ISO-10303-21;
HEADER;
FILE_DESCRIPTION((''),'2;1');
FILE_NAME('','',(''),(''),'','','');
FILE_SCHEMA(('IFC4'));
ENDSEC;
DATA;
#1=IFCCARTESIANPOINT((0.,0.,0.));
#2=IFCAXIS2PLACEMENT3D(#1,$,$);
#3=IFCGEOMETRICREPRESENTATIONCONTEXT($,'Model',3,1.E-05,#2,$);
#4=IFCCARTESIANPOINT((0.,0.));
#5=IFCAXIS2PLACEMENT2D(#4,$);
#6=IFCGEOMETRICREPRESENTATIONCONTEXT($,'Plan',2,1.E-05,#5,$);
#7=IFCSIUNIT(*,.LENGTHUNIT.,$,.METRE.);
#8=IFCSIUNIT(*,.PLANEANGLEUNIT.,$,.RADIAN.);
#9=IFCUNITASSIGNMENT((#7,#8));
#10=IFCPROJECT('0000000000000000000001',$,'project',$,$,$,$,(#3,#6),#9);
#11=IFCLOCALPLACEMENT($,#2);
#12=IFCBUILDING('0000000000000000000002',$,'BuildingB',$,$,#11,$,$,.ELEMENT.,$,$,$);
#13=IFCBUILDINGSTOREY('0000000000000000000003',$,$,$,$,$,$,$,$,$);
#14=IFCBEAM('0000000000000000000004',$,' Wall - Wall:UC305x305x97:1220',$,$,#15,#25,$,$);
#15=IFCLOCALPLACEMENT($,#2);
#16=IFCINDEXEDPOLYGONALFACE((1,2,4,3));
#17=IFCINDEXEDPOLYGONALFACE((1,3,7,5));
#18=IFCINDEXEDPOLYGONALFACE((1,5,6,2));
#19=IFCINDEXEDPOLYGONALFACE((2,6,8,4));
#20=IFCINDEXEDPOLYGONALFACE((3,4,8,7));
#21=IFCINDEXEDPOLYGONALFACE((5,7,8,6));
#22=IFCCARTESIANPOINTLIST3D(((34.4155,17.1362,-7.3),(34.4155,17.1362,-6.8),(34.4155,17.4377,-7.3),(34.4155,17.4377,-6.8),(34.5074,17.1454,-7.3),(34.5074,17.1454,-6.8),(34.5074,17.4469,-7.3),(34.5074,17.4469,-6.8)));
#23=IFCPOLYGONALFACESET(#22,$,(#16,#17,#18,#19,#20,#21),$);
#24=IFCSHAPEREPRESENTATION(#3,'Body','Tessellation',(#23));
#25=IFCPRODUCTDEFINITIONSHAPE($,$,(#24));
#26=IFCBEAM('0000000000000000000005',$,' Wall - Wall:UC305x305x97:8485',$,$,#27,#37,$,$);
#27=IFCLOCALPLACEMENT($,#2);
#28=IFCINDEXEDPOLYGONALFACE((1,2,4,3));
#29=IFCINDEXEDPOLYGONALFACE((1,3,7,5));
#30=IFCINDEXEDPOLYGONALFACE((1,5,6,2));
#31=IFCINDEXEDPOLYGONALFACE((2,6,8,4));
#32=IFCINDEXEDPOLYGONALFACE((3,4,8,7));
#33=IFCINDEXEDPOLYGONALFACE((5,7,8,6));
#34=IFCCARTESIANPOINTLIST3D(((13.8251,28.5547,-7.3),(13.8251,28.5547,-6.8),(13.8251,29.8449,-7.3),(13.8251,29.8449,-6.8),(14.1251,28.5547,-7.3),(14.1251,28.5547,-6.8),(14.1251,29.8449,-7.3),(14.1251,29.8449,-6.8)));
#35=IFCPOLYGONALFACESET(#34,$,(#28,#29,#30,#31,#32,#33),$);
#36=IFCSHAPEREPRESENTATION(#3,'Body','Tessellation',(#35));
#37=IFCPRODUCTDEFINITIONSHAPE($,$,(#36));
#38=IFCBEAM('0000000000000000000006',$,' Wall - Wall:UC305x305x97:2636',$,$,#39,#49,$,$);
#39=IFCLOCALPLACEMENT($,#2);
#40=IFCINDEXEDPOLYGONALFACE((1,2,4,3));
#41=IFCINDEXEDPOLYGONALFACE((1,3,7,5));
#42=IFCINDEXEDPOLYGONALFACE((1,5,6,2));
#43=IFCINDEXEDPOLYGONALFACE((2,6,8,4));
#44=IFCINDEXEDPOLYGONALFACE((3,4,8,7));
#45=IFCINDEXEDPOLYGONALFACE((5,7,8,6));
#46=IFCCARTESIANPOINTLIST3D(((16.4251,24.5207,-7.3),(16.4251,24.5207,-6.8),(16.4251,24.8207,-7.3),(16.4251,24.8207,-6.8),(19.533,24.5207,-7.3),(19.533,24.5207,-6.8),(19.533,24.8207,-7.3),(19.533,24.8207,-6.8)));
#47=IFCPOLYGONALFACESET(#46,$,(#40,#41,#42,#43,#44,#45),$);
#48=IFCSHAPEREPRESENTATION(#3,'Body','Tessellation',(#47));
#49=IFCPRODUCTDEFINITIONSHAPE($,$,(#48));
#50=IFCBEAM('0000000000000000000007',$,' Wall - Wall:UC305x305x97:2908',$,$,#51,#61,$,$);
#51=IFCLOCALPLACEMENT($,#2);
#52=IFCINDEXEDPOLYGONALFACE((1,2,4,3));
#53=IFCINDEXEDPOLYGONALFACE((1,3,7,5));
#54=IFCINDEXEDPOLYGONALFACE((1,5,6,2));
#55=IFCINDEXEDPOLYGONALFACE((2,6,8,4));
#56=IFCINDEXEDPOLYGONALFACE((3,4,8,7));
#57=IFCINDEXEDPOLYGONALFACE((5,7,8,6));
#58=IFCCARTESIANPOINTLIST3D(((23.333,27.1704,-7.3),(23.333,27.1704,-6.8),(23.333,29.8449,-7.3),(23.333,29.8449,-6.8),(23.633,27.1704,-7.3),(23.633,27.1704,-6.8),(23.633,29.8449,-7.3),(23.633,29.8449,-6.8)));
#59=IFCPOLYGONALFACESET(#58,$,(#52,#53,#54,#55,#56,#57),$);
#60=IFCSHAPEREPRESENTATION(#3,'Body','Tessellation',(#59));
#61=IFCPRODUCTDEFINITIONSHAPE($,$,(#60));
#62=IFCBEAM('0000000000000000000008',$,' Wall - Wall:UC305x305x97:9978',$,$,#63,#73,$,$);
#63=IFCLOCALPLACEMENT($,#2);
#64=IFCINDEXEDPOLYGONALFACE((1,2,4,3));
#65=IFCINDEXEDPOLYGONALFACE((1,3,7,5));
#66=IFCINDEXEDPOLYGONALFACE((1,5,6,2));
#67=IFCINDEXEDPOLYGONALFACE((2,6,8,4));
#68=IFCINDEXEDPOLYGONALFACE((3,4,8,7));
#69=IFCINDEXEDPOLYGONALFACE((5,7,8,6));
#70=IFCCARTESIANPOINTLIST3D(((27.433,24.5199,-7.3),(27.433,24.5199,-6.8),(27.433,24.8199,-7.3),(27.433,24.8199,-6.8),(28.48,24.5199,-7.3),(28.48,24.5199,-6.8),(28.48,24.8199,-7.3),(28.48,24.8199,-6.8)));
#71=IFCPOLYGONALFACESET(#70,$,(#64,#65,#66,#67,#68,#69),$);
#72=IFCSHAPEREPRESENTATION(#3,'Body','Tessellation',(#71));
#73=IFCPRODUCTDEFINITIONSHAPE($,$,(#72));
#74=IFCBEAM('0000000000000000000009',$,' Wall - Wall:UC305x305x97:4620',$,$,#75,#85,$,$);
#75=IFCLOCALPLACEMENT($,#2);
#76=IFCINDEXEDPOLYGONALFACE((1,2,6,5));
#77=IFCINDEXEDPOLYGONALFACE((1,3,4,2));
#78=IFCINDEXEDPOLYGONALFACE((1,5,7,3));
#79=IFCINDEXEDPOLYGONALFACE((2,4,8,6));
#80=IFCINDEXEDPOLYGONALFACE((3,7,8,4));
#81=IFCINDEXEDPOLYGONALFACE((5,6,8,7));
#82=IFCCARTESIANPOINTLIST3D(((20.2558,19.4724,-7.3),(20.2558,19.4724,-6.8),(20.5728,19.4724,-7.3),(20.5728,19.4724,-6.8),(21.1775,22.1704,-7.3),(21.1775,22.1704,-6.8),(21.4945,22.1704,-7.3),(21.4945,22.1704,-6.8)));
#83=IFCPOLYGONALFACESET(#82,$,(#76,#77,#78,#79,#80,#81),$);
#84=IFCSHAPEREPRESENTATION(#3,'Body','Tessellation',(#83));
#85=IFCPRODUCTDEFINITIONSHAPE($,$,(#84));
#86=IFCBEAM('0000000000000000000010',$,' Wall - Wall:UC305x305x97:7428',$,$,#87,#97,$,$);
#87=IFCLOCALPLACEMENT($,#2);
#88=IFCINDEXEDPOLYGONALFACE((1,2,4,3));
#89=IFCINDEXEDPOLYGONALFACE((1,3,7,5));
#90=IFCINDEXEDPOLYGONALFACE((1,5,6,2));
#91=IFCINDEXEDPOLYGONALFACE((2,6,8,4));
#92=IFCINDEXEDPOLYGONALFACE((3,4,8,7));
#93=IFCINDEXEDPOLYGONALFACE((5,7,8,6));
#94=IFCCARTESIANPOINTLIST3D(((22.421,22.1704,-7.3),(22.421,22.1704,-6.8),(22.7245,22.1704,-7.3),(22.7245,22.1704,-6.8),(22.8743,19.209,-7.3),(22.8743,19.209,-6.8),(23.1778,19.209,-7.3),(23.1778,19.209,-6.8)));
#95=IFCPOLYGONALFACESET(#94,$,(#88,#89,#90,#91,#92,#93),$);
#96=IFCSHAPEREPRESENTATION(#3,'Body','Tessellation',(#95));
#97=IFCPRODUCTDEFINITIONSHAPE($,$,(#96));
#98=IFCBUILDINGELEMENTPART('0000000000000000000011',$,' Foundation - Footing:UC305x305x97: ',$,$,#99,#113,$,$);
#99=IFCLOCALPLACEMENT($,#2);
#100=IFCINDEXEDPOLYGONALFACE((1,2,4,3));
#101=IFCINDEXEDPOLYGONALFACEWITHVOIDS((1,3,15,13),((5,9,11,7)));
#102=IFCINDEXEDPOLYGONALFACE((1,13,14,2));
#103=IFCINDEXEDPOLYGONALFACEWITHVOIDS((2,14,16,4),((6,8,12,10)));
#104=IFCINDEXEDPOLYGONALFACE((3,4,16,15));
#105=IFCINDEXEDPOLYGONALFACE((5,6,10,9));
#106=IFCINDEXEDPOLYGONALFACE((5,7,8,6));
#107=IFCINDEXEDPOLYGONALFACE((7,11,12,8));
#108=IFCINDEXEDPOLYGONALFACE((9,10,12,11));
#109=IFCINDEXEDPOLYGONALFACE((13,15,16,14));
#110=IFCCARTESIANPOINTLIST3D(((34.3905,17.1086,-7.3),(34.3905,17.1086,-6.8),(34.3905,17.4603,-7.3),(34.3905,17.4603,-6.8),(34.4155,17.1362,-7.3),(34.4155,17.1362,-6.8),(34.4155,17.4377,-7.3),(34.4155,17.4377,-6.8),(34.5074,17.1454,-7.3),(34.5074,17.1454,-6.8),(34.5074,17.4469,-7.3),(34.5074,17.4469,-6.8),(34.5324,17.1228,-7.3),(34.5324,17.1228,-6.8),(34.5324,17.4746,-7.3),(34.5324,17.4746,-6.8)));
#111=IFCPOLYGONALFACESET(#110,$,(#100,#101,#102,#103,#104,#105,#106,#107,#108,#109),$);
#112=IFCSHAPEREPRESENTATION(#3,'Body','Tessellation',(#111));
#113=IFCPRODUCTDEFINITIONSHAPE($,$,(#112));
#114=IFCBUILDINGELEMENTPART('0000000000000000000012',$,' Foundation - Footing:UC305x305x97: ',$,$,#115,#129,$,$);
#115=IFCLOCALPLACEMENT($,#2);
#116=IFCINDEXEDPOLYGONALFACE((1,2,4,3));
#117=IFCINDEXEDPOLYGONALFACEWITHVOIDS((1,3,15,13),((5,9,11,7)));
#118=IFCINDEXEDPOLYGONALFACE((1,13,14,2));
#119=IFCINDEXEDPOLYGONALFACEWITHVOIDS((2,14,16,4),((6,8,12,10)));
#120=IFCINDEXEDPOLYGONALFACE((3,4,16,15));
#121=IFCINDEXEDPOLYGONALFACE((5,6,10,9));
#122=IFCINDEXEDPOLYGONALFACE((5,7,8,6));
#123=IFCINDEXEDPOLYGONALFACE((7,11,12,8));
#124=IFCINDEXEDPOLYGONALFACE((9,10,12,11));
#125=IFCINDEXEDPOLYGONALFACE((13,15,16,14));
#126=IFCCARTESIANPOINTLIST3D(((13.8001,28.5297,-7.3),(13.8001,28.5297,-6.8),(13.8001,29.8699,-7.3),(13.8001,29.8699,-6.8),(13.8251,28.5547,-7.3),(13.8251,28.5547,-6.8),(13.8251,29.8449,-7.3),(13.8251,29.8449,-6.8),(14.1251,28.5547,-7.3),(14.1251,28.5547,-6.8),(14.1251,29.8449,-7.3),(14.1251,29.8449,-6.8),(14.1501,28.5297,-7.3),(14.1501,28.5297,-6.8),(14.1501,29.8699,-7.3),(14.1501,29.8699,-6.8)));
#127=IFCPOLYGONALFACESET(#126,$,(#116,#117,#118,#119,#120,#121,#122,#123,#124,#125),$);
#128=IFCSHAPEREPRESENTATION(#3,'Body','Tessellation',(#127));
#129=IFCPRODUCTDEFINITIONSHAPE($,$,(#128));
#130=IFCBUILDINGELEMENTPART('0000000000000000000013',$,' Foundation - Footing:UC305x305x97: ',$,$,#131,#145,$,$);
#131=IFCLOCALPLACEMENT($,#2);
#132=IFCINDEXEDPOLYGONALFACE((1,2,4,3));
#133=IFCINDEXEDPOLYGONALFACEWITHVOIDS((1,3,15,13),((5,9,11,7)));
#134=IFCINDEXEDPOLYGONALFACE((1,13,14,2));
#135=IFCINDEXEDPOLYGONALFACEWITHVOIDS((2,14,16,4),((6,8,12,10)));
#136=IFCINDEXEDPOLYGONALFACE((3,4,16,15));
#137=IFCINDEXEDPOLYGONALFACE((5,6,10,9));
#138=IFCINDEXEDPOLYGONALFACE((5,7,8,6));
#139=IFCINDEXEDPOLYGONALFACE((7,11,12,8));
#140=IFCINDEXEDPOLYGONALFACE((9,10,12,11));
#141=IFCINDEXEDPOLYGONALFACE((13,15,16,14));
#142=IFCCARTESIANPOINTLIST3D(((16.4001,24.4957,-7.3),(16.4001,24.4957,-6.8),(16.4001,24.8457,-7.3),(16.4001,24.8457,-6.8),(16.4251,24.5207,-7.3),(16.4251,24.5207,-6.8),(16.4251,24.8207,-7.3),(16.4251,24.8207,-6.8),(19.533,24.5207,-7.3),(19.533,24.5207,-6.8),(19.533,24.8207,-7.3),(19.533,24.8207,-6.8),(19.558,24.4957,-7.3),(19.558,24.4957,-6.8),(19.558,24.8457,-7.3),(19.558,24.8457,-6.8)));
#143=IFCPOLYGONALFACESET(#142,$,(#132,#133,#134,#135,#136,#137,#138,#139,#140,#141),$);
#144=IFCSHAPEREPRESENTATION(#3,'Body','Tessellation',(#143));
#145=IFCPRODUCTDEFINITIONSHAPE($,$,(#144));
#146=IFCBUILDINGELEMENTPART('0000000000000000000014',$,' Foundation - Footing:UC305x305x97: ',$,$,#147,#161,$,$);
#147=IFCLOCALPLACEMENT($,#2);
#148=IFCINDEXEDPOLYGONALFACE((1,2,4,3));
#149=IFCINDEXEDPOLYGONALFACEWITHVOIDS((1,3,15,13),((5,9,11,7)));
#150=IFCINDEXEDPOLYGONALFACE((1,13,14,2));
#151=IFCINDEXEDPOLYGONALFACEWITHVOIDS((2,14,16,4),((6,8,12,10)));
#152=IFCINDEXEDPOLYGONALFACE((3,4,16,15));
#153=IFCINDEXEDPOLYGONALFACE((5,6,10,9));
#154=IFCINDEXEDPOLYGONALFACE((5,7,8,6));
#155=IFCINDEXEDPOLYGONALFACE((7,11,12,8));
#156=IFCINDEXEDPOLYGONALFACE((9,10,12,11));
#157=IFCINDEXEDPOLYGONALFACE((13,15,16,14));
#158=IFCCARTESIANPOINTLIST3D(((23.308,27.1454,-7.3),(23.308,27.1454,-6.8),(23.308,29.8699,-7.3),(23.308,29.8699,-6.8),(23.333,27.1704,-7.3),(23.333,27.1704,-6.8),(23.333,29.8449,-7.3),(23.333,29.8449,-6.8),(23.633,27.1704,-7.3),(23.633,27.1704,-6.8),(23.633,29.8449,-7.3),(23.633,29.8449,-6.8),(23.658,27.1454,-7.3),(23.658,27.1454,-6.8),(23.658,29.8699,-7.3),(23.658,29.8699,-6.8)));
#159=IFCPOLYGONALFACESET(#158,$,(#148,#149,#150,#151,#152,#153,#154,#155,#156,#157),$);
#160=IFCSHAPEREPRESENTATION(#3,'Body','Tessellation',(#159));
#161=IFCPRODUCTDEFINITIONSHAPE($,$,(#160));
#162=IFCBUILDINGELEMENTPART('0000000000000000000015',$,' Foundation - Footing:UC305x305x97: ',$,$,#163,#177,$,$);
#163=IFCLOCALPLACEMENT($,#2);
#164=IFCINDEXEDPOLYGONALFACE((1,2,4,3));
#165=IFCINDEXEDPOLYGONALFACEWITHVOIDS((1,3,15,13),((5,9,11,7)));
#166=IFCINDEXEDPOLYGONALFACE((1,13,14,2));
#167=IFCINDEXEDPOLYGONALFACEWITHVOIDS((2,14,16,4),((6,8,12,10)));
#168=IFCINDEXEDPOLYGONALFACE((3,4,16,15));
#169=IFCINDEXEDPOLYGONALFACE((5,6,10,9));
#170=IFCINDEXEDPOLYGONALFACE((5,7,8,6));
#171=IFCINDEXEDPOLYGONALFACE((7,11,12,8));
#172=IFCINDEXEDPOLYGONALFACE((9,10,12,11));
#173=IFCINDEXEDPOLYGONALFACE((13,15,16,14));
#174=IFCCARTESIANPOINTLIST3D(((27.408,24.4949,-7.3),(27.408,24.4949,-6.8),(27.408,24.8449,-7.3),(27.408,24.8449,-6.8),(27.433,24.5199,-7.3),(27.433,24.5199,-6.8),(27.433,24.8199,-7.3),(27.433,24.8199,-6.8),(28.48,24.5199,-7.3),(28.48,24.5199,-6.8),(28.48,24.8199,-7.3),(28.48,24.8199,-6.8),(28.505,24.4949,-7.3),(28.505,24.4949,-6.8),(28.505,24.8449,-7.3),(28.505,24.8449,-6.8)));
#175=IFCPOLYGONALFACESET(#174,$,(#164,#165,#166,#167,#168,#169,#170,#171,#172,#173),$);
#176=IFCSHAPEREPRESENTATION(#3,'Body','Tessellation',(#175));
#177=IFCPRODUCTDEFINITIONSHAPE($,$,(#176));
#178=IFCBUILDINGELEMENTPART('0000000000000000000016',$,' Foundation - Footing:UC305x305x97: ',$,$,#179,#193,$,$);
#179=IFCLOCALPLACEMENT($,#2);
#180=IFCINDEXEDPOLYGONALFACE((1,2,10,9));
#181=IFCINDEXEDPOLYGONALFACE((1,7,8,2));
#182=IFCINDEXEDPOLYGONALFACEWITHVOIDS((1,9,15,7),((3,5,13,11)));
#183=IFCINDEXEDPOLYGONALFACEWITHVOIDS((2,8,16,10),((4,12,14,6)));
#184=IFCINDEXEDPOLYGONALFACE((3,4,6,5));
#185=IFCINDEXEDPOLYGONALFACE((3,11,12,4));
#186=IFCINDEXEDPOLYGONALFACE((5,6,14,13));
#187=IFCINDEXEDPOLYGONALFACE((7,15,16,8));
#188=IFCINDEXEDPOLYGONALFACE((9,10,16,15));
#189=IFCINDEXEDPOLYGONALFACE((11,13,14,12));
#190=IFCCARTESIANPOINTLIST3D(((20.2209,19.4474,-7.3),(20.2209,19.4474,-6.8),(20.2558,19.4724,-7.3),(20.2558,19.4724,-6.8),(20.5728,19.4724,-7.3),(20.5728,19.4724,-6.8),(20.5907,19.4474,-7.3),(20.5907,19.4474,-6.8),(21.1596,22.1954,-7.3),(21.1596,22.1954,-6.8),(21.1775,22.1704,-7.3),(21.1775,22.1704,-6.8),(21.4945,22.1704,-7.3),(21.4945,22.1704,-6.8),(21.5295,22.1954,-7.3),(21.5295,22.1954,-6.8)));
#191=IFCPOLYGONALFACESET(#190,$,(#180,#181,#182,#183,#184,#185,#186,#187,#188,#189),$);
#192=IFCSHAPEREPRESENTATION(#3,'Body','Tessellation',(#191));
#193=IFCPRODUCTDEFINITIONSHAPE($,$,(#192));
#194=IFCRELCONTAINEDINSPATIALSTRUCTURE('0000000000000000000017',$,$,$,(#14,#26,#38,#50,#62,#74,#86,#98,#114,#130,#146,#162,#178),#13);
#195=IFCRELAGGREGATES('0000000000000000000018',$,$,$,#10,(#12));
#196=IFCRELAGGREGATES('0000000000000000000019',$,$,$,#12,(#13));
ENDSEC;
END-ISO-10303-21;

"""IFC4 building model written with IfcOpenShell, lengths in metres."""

from ifc_helpers import new_model, si_unit, origin, origin_2d, place, context, project, spatial, polyline, outline, extrude, element, save


model = new_model("IFC4")

# Units and contexts
model_context = context("Model", 3, precision=1e-05, world=origin())
plan_context = context("Plan", 2, precision=1e-05, world=origin_2d())
ifc_project = project(units=[si_unit("LENGTHUNIT", "METRE"), si_unit("PLANEANGLEUNIT", "RADIAN")], contexts=[model_context, plan_context])

# Building, storey
building_placement = place(None, origin())
building = spatial("IfcBuilding", under=ifc_project, at=building_placement, Name="BuildingB", CompositionType="ELEMENT")
storey = spatial("IfcBuildingStorey", under=building)

# Beams
element("IfcBeam", 1, inside=storey, Name=" Wall - Wall:UC305x305x97:1220", context=model_context, shape_type="SweptSolid", body=[
    extrude(outline(polyline([(34.4155, 17.1362, -7.3), (34.5074, 17.1454, -7.3), (34.5074, 17.4469, -7.3), (34.4155, 17.4377, -7.3), (34.4155, 17.1362, -7.3)])), None, (0.0, 0.0, 1.0), 0.5),
])
element("IfcBeam", 2, inside=storey, Name=" Wall - Wall:UC305x305x97:8485", context=model_context, shape_type="SweptSolid", body=[
    extrude(outline(polyline([(13.8251, 28.5547, -7.3), (14.1251, 28.5547, -7.3), (14.1251, 29.8449, -7.3), (13.8251, 29.8449, -7.3), (13.8251, 28.5547, -7.3)])), None, (0.0, 0.0, 1.0), 0.5),
])
element("IfcBeam", 3, inside=storey, Name=" Wall - Wall:UC305x305x97:2636", context=model_context, shape_type="SweptSolid", body=[
    extrude(outline(polyline([(16.4251, 24.5207, -7.3), (16.4251, 24.8207, -7.3), (19.533, 24.8207, -7.3), (19.533, 24.5207, -7.3), (16.4251, 24.5207, -7.3)])), None, (0.0, 0.0, 1.0), 0.5),
])
element("IfcBeam", 4, inside=storey, Name=" Wall - Wall:UC305x305x97:2908", context=model_context, shape_type="SweptSolid", body=[
    extrude(outline(polyline([(23.333, 27.1704, -7.3), (23.633, 27.1704, -7.3), (23.633, 29.8449, -7.3), (23.333, 29.8449, -7.3), (23.333, 27.1704, -7.3)])), None, (0.0, 0.0, 1.0), 0.5),
])
element("IfcBeam", 5, inside=storey, Name=" Wall - Wall:UC305x305x97:9978", context=model_context, shape_type="SweptSolid", body=[
    extrude(outline(polyline([(27.433, 24.5199, -7.3), (27.433, 24.8199, -7.3), (28.48, 24.8199, -7.3), (28.48, 24.5199, -7.3), (27.433, 24.5199, -7.3)])), None, (0.0, 0.0, 1.0), 0.5),
])
element("IfcBeam", 6, inside=storey, Name=" Wall - Wall:UC305x305x97:4620", context=model_context, shape_type="SweptSolid", body=[
    extrude(outline(polyline([(20.2558, 19.4724, -7.3), (20.5728, 19.4724, -7.3), (21.4945, 22.1704, -7.3), (21.1775, 22.1704, -7.3), (20.2558, 19.4724, -7.3)])), None, (0.0, 0.0, 1.0), 0.5),
])
element("IfcBeam", 7, inside=storey, Name=" Wall - Wall:UC305x305x97:7428", context=model_context, shape_type="SweptSolid", body=[
    extrude(outline(polyline([(22.8743, 19.209, -7.3), (23.1778, 19.209, -7.3), (22.7245, 22.1704, -7.3), (22.421, 22.1704, -7.3), (22.8743, 19.209, -7.3)])), None, (0.0, 0.0, 1.0), 0.5),
])

# Building element parts, openings
building_element_part_1 = element("IfcBuildingElementPart", 8, inside=storey, Name=" Foundation - Footing:UC305x305x97: ", context=model_context, shape_type="SweptSolid", body=[
    extrude(outline(polyline([(34.3905, 17.1086, -7.3), (34.5324, 17.1228, -7.3), (34.5324, 17.4746, -7.3), (34.3905, 17.4603, -7.3), (34.3905, 17.1086, -7.3)])), None, (0.0, 0.0, 1.0), 0.5),
])
element("IfcOpeningElement", 9, inside=storey, cuts=building_element_part_1, context=model_context, shape_type="SweptSolid", body=[
    extrude(outline(polyline([(34.4155, 17.1362, -7.3), (34.5074, 17.1454, -7.3), (34.5074, 17.4469, -7.3), (34.4155, 17.4377, -7.3), (34.4155, 17.1362, -7.3)])), None, (0.0, 0.0, 1.0), 0.5),
])
building_element_part_2 = element("IfcBuildingElementPart", 10, inside=storey, Name=" Foundation - Footing:UC305x305x97: ", context=model_context, shape_type="SweptSolid", body=[
    extrude(outline(polyline([(13.8001, 28.5297, -7.3), (14.1501, 28.5297, -7.3), (14.1501, 29.8699, -7.3), (13.8001, 29.8699, -7.3), (13.8001, 28.5297, -7.3)])), None, (0.0, 0.0, 1.0), 0.5),
])
element("IfcOpeningElement", 11, inside=storey, cuts=building_element_part_2, context=model_context, shape_type="SweptSolid", body=[
    extrude(outline(polyline([(13.8251, 28.5547, -7.3), (14.1251, 28.5547, -7.3), (14.1251, 29.8449, -7.3), (13.8251, 29.8449, -7.3), (13.8251, 28.5547, -7.3)])), None, (0.0, 0.0, 1.0), 0.5),
])
building_element_part_3 = element("IfcBuildingElementPart", 12, inside=storey, Name=" Foundation - Footing:UC305x305x97: ", context=model_context, shape_type="SweptSolid", body=[
    extrude(outline(polyline([(16.4001, 24.4957, -7.3), (16.4001, 24.8457, -7.3), (19.558, 24.8457, -7.3), (19.558, 24.4957, -7.3), (16.4001, 24.4957, -7.3)])), None, (0.0, 0.0, 1.0), 0.5),
])
element("IfcOpeningElement", 13, inside=storey, cuts=building_element_part_3, context=model_context, shape_type="SweptSolid", body=[
    extrude(outline(polyline([(16.4251, 24.5207, -7.3), (16.4251, 24.8207, -7.3), (19.533, 24.8207, -7.3), (19.533, 24.5207, -7.3), (16.4251, 24.5207, -7.3)])), None, (0.0, 0.0, 1.0), 0.5),
])
building_element_part_4 = element("IfcBuildingElementPart", 14, inside=storey, Name=" Foundation - Footing:UC305x305x97: ", context=model_context, shape_type="SweptSolid", body=[
    extrude(outline(polyline([(23.308, 27.1454, -7.3), (23.658, 27.1454, -7.3), (23.658, 29.8699, -7.3), (23.308, 29.8699, -7.3), (23.308, 27.1454, -7.3)])), None, (0.0, 0.0, 1.0), 0.5),
])
element("IfcOpeningElement", 15, inside=storey, cuts=building_element_part_4, context=model_context, shape_type="SweptSolid", body=[
    extrude(outline(polyline([(23.333, 27.1704, -7.3), (23.633, 27.1704, -7.3), (23.633, 29.8449, -7.3), (23.333, 29.8449, -7.3), (23.333, 27.1704, -7.3)])), None, (0.0, 0.0, 1.0), 0.5),
])
building_element_part_5 = element("IfcBuildingElementPart", 16, inside=storey, Name=" Foundation - Footing:UC305x305x97: ", context=model_context, shape_type="SweptSolid", body=[
    extrude(outline(polyline([(27.408, 24.4949, -7.3), (27.408, 24.8449, -7.3), (28.505, 24.8449, -7.3), (28.505, 24.4949, -7.3), (27.408, 24.4949, -7.3)])), None, (0.0, 0.0, 1.0), 0.5),
])
element("IfcOpeningElement", 17, inside=storey, cuts=building_element_part_5, context=model_context, shape_type="SweptSolid", body=[
    extrude(outline(polyline([(27.433, 24.5199, -7.3), (27.433, 24.8199, -7.3), (28.48, 24.8199, -7.3), (28.48, 24.5199, -7.3), (27.433, 24.5199, -7.3)])), None, (0.0, 0.0, 1.0), 0.5),
])
building_element_part_6 = element("IfcBuildingElementPart", 18, inside=storey, Name=" Foundation - Footing:UC305x305x97: ", context=model_context, shape_type="SweptSolid", body=[
    extrude(outline(polyline([(20.2209, 19.4474, -7.3), (20.5907, 19.4474, -7.3), (21.5295, 22.1954, -7.3), (21.1596, 22.1954, -7.3), (20.2209, 19.4474, -7.3)])), None, (0.0, 0.0, 1.0), 0.5),
])
element("IfcOpeningElement", 19, inside=storey, cuts=building_element_part_6, context=model_context, shape_type="SweptSolid", body=[
    extrude(outline(polyline([(20.2558, 19.4724, -7.3), (20.5728, 19.4724, -7.3), (21.4945, 22.1704, -7.3), (21.1775, 22.1704, -7.3), (20.2558, 19.4724, -7.3)])), None, (0.0, 0.0, 1.0), 0.5),
])

save(model, "model.ifc")
